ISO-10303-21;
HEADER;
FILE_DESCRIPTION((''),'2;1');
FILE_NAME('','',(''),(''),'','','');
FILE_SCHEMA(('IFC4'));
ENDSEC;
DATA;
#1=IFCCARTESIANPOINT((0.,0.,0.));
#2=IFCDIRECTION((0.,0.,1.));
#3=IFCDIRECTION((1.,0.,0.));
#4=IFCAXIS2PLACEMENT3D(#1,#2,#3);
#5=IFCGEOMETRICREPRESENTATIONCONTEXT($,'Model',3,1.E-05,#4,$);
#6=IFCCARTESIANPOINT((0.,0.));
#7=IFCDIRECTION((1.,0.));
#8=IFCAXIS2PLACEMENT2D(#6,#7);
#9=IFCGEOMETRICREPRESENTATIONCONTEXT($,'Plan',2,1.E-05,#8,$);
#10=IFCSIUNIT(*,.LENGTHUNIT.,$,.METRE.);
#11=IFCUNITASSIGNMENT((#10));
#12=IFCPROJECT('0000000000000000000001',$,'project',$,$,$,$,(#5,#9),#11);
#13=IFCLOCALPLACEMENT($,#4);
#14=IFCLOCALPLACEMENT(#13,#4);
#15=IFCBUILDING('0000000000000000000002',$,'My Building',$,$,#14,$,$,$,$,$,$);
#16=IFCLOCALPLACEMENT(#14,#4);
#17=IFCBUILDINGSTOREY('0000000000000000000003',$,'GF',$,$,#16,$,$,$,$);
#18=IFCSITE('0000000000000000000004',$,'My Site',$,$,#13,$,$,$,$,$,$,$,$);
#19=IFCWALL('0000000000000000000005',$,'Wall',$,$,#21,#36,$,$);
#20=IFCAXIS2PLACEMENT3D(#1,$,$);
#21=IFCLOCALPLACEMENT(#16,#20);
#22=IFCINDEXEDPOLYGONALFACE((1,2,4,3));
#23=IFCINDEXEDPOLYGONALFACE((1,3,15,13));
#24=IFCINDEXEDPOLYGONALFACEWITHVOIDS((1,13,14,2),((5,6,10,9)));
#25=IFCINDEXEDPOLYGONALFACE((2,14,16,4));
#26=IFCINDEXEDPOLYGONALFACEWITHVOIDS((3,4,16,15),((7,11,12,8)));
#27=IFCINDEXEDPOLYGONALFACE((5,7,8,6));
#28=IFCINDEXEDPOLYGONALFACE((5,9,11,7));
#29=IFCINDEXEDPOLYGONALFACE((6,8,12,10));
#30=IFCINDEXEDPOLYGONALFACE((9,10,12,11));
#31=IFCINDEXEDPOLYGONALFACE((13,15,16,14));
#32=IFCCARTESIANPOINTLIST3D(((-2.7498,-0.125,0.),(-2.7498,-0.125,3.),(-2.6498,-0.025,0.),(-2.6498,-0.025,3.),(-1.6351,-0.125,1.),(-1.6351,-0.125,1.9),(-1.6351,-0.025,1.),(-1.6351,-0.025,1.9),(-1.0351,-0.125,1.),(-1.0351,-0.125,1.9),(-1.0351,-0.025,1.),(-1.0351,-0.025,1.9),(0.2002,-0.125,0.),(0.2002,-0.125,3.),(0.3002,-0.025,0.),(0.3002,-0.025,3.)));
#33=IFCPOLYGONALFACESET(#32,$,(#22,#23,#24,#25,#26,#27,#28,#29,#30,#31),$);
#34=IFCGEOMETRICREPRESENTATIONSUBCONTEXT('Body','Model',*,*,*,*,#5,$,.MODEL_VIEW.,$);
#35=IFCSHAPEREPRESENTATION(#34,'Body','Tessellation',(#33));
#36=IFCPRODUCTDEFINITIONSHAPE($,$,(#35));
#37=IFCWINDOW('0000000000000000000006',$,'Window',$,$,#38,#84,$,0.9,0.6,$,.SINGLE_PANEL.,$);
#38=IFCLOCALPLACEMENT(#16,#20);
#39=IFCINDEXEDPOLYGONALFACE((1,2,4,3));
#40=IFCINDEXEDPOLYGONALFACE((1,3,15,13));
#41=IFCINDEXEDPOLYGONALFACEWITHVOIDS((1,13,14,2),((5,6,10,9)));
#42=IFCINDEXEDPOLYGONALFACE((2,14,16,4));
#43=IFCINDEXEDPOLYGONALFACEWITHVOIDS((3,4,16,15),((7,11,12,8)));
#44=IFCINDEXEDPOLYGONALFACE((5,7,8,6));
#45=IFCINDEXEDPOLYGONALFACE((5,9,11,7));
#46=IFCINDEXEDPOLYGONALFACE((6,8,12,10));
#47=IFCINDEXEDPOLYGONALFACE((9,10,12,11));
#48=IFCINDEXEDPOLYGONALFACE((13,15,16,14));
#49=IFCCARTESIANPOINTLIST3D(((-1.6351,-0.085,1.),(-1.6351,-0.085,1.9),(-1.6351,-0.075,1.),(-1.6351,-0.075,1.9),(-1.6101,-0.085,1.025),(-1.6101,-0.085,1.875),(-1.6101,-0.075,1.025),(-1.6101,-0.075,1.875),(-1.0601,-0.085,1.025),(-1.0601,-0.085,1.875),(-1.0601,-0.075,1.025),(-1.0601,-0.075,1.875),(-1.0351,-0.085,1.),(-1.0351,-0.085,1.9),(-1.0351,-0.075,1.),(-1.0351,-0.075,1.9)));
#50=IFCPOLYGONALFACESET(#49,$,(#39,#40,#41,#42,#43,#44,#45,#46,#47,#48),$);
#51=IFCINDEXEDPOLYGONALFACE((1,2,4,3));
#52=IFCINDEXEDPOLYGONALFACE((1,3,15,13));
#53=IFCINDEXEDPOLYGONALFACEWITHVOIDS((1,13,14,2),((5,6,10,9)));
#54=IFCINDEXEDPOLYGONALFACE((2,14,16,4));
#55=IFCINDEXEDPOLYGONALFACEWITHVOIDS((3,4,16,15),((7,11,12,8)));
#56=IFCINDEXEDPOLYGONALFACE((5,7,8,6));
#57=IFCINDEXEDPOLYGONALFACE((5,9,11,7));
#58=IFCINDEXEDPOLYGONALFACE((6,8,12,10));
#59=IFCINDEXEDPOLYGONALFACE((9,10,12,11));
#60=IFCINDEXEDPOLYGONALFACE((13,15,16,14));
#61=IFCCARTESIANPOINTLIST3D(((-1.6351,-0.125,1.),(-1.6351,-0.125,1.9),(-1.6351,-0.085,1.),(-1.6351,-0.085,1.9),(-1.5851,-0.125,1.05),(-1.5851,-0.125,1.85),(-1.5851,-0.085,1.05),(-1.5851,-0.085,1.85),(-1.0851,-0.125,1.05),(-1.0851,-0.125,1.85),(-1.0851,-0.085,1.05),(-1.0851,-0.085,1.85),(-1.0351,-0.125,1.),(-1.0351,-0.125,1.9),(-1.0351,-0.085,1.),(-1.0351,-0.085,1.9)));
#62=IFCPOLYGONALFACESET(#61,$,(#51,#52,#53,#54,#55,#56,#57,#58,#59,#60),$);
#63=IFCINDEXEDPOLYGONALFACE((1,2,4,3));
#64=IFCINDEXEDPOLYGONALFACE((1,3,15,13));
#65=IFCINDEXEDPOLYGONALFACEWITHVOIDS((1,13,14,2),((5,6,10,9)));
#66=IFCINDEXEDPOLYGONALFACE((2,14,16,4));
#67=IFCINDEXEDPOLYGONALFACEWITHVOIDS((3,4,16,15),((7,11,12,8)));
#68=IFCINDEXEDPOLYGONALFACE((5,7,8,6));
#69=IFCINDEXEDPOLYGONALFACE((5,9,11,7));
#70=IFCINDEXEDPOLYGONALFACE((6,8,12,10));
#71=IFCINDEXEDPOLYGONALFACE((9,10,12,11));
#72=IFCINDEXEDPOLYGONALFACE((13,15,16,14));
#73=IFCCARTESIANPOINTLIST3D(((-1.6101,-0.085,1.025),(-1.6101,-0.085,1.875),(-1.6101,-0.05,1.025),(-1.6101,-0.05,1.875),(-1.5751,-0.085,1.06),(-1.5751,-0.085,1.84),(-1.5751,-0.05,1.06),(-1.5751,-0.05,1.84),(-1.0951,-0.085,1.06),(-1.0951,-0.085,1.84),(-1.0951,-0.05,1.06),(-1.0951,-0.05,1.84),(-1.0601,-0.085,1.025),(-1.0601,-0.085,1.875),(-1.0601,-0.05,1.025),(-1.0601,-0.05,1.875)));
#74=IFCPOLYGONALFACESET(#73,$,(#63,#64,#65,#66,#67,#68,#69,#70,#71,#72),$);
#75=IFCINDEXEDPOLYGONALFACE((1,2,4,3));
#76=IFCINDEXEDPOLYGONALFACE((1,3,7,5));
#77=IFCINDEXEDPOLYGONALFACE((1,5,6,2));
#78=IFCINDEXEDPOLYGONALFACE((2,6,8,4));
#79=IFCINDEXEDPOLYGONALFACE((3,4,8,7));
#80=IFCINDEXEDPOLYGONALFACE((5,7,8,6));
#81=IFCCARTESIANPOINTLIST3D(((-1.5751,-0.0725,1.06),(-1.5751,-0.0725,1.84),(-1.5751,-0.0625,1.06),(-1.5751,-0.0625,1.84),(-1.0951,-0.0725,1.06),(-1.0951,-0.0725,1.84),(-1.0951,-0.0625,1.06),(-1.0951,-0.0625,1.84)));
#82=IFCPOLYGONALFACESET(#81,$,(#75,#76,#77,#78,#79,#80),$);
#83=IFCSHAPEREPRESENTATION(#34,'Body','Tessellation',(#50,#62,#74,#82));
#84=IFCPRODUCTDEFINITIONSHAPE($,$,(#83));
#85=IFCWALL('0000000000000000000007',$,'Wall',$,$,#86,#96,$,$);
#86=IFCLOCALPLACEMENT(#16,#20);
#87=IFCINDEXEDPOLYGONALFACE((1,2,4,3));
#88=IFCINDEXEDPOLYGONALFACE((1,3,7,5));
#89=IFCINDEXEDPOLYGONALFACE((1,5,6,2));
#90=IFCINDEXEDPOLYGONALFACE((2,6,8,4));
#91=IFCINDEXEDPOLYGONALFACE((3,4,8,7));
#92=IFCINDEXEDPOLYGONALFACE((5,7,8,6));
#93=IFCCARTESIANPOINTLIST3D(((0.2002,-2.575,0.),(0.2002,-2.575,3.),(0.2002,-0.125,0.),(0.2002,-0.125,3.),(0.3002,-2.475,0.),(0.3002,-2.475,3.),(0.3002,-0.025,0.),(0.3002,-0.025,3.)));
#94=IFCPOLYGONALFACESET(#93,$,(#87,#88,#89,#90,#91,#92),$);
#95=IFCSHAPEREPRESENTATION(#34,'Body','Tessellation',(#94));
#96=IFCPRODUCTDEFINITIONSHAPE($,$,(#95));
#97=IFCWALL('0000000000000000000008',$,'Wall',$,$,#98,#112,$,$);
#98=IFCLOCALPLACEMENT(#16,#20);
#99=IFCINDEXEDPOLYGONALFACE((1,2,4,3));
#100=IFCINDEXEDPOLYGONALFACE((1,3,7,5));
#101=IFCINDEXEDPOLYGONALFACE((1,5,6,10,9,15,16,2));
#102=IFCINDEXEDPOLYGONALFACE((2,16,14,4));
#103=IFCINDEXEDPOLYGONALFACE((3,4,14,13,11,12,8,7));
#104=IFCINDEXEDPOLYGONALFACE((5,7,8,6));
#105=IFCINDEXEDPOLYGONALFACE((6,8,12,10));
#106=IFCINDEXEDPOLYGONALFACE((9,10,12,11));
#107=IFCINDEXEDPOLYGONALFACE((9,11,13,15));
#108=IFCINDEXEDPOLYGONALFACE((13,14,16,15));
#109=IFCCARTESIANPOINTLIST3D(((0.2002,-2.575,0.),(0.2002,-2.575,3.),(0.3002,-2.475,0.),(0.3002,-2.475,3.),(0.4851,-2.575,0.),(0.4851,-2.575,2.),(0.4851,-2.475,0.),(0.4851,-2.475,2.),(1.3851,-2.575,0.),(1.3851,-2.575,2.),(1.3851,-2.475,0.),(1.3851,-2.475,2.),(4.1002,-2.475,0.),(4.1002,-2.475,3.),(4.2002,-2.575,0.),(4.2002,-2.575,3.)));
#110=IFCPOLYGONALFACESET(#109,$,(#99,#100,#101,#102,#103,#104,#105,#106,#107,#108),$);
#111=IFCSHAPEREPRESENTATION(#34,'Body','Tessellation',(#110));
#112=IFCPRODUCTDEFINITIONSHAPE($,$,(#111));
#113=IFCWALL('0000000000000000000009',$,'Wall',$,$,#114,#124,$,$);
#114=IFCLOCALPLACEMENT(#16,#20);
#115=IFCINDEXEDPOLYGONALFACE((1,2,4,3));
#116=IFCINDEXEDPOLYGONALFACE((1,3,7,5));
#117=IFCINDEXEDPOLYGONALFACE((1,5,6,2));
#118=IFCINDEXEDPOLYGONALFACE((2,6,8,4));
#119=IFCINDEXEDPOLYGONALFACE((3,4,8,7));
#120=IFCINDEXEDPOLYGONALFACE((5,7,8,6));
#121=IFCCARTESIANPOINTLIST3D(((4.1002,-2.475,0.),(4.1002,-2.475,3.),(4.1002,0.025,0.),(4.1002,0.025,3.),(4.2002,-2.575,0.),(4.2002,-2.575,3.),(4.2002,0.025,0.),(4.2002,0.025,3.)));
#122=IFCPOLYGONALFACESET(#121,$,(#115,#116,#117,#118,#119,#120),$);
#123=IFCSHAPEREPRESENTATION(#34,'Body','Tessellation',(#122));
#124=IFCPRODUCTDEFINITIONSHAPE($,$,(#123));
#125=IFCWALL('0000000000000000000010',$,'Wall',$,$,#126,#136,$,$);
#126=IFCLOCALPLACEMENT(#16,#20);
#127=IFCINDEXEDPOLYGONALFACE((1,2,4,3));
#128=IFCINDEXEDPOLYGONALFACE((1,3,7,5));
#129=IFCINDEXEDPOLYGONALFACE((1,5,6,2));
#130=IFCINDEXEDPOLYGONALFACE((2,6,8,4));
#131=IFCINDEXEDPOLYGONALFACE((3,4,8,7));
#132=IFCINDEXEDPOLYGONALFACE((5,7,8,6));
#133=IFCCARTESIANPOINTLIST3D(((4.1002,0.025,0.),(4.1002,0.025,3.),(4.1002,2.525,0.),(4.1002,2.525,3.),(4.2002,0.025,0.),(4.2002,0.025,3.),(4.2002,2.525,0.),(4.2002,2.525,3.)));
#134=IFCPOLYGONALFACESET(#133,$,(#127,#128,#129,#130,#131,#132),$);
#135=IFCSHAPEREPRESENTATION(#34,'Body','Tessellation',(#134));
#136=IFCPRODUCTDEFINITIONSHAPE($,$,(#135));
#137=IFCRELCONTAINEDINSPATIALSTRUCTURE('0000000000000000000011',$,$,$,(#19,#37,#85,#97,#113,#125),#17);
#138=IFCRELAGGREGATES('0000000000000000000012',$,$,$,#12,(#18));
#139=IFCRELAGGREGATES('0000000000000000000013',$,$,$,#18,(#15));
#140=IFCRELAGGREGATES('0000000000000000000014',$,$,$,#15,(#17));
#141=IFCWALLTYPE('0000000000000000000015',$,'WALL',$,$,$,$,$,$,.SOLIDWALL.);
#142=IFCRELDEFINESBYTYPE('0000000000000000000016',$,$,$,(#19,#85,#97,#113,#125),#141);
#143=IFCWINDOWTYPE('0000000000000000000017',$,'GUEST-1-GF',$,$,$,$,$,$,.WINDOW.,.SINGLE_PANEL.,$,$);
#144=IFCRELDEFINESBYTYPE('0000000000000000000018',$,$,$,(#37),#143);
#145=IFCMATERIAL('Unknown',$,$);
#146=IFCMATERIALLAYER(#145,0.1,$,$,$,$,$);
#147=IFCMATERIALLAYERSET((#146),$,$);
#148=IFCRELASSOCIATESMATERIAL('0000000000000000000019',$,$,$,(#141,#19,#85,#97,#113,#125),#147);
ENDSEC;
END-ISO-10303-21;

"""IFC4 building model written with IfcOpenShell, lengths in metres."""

from ifc_helpers import new_model, entity, si_unit, frame, origin_with_axes, origin_2d_with_axis, place, context, subcontext, project, spatial, line, indexed_curve, outline, extrude, shape, source, transform, mapped, material, layer, layer_set, layer_usage, type_object, type_shapes, element, fill, save


model = new_model("IFC4")

# Units and contexts
model_context = context("Model", 3, precision=1e-05, world=origin_with_axes())
plan_context = context("Plan", 2, precision=1e-05, world=origin_2d_with_axis())
body_context_1 = subcontext(model_context, "Body", "Model", "MODEL_VIEW")
body_context_2 = subcontext(plan_context, "Body", "Plan", "PLAN_VIEW")
ifc_project = project(units=[si_unit("LENGTHUNIT", "METRE")], contexts=[model_context, plan_context])

# Site, building, storey
site_placement = place(None, origin_with_axes())
site = spatial("IfcSite", under=ifc_project, at=site_placement, Name="My Site")
building_placement = place(site_placement, origin_with_axes())
building = spatial("IfcBuilding", under=site, at=building_placement, Name="My Building")
storey_placement = place(building_placement, origin_with_axes())
storey = spatial("IfcBuildingStorey", under=building, at=storey_placement, Name="GF")

# Shared definitions
ifc_material = material(Name="Unknown")

# Wall, opening, window
ifc_layer_1 = layer(ifc_material, 0.1)
ifc_layer_set_1 = layer_set([ifc_layer_1])
ifc_layer_usage_1 = layer_usage(ifc_layer_set_1, "AXIS2", "POSITIVE", 0.0)
wall_type = type_object("IfcWallType", Name="WALL", PredefinedType="SOLIDWALL", material=ifc_layer_set_1)
wall_1_placement = place(storey_placement, frame((-2.7498, -0.125, 0.0), z_axis=(0.0, 0.0, 1.0), x_axis=(1.0, 0.0, 0.0)))
wall_1 = element("IfcWall", 1, at=wall_1_placement, inside=storey, type_object=wall_type, material=ifc_layer_usage_1, Name="Wall", context=body_context_1, shape_type="SweptSolid", body=[
    extrude(outline(indexed_curve([(0.0, 0.0), (0.1, 0.1), (3.05, 0.1), (2.95, 0.0)], segments=[line(1, 2, 3, 4, 1)])), origin_with_axes(), (0.0, 0.0, 1.0), 3.0),
])
shared_shape_1 = source(origin_with_axes(), body_context_1, "Body", "SweptSolid", [
    extrude(outline(indexed_curve([(0.0, 0.0), (0.6, 0.0), (0.6, 0.9), (0.0, 0.9)], segments=[line(1, 2, 3, 4, 1)])), frame((0.0, -0.6, 0.0), z_axis=(0.0, -1.0, 0.0), x_axis=(1.0, 0.0, 0.0)), (0.0, 0.0, -1.0), 1.2),
])
opening_1_placement = place(wall_1_placement, frame((1.1146, -0.05, 1.0), z_axis=(0.0, 0.0, 1.0), x_axis=(1.0, 0.0, 0.0)))
opening_1 = element("IfcOpeningElement", 2, at=opening_1_placement, cuts=wall_1, PredefinedType="OPENING", context=body_context_1, shape_type="MappedRepresentation", body=[
    mapped(shared_shape_1, transform((0.0, 0.0, 0.0), x_axis=(1.0, 0.0, 0.0), y_axis=(0.0, 1.0, 0.0), z_axis=(0.0, 0.0, 1.0), scale=1.0)),
])
window_type_1 = type_object("IfcWindowType", Name="GUEST-1-GF", PartitioningType="SINGLE_PANEL", PredefinedType="WINDOW")
shared_shape_2 = source(origin_with_axes(), body_context_1, "Body", "SweptSolid", [
    extrude(outline(indexed_curve([(0.0, 0.0), (0.6, 0.0), (0.6, 0.9), (0.0, 0.9)], segments=[line(1, 2, 3, 4, 1)]), holes=[indexed_curve([(0.025, 0.025), (0.575, 0.025), (0.575, 0.875), (0.025, 0.875)], segments=[line(1, 2, 3, 4, 1)])]), frame((0.0, 0.09, 0.0), z_axis=(0.0, -1.0, 0.0), x_axis=(1.0, 0.0, 0.0)), (0.0, 0.0, -1.0), 0.01),
    extrude(outline(indexed_curve([(0.0, 0.0), (0.6, 0.0), (0.6, 0.9), (0.0, 0.9)], segments=[line(1, 2, 3, 4, 1)]), holes=[indexed_curve([(0.05, 0.05), (0.55, 0.05), (0.55, 0.85), (0.05, 0.85)], segments=[line(1, 2, 3, 4, 1)])]), frame((0.0, 0.05, 0.0), z_axis=(0.0, -1.0, 0.0), x_axis=(1.0, 0.0, 0.0)), (0.0, 0.0, -1.0), 0.04),
    extrude(outline(indexed_curve([(0.0, 0.0), (0.55, 0.0), (0.55, 0.85), (0.0, 0.85)], segments=[line(1, 2, 3, 4, 1)]), holes=[indexed_curve([(0.035, 0.035), (0.515, 0.035), (0.515, 0.815), (0.035, 0.815)], segments=[line(1, 2, 3, 4, 1)])]), frame((0.025, 0.09, 0.025), z_axis=(0.0, -1.0, 0.0), x_axis=(1.0, 0.0, 0.0)), (0.0, 0.0, -1.0), 0.035),
    extrude(outline(indexed_curve([(0.035, 0.035), (0.515, 0.035), (0.515, 0.815), (0.035, 0.815)], segments=[line(1, 2, 3, 4, 1)])), frame((0.025, 0.1025, 0.025), z_axis=(0.0, -1.0, 0.0), x_axis=(1.0, 0.0, 0.0)), (0.0, 0.0, -1.0), 0.01),
])
shared_shape_3 = source(origin_with_axes(), body_context_2, "Body", "Curve2D", [
    entity("IfcIndexedPolyCurve", entity("IfcCartesianPointList2D", [[0.05, 0.05], [0.55, 0.05]])),
    entity("IfcIndexedPolyCurve", entity("IfcCartesianPointList2D", [[0.0, 0.1], [0.025, 0.1], [0.025, 0.09], [0.05, 0.09], [0.05, 0.05], [0.0, 0.05]]), [entity("IfcLineIndex", [1, 2, 3, 4, 5, 6, 1])]),
    entity("IfcIndexedPolyCurve", entity("IfcCartesianPointList2D", [[0.6, 0.1], [0.575, 0.1], [0.575, 0.09], [0.55, 0.09], [0.55, 0.05], [0.6, 0.05]]), [entity("IfcLineIndex", [1, 2, 3, 4, 5, 6, 1])]),
    entity("IfcIndexedPolyCurve", entity("IfcCartesianPointList2D", [[0.025, 0.09], [0.06, 0.09], [0.06, 0.125], [0.025, 0.125]]), [entity("IfcLineIndex", [1, 2, 3, 4, 1])]),
    entity("IfcIndexedPolyCurve", entity("IfcCartesianPointList2D", [[0.575, 0.09], [0.54, 0.09], [0.54, 0.125], [0.575, 0.125]]), [entity("IfcLineIndex", [1, 2, 3, 4, 1])]),
    entity("IfcIndexedPolyCurve", entity("IfcCartesianPointList2D", [[0.06, 0.09], [0.54, 0.09]])),
    entity("IfcIndexedPolyCurve", entity("IfcCartesianPointList2D", [[0.06, 0.125], [0.54, 0.125]])),
    entity("IfcIndexedPolyCurve", entity("IfcCartesianPointList2D", [[0.06, 0.1075], [0.54, 0.1075]])),
])
type_shapes(window_type_1, [shared_shape_2, shared_shape_3])
window_1_placement = place(opening_1_placement, frame((0.0, 0.0, 0.0), z_axis=(0.0, 0.0, 1.0), x_axis=(1.0, 0.0, 0.0)))
window_1 = element("IfcWindow", 3, at=window_1_placement, inside=storey, type_object=window_type_1, Name="Window", OverallHeight=0.9, OverallWidth=0.6, PartitioningType="SINGLE_PANEL", shapes=[
    shape(body_context_1, "Body", "MappedRepresentation", [mapped(shared_shape_2, transform((0.0, 0.0, 0.0), x_axis=(1.0, 0.0, 0.0), y_axis=(0.0, 1.0, 0.0), z_axis=(0.0, 0.0, 1.0), scale=1.0))]),
    shape(body_context_2, "Body", "MappedRepresentation", [mapped(shared_shape_3, transform((0.0, 0.0, 0.0), x_axis=(1.0, 0.0, 0.0), y_axis=(0.0, 1.0, 0.0), z_axis=(0.0, 0.0, 1.0), scale=1.0))]),
])
fill(opening_1, window_1)

# Wall
ifc_layer_usage_2 = layer_usage(ifc_layer_set_1, "AXIS2", "POSITIVE", 0.0)
wall_2_placement = place(storey_placement, frame((0.2002, -0.125, 0.0), z_axis=(0.0, 0.0, 1.0), x_axis=(0.0, -1.0, 0.0)))
element("IfcWall", 4, at=wall_2_placement, inside=storey, type_object=wall_type, material=ifc_layer_usage_2, Name="Wall", context=body_context_1, shape_type="SweptSolid", body=[
    extrude(outline(indexed_curve([(0.0, 0.0), (-0.1, 0.1), (2.35, 0.1), (2.45, 0.0)], segments=[line(1, 2, 3, 4, 1)])), origin_with_axes(), (0.0, 0.0, 1.0), 3.0),
])

# Wall, opening
ifc_layer_usage_3 = layer_usage(ifc_layer_set_1, "AXIS2", "POSITIVE", 0.0)
wall_3_placement = place(storey_placement, frame((0.2002, -2.575, 0.0), z_axis=(0.0, 0.0, 1.0), x_axis=(1.0, 0.0, 0.0)))
wall_3 = element("IfcWall", 5, at=wall_3_placement, inside=storey, type_object=wall_type, material=ifc_layer_usage_3, Name="Wall", context=body_context_1, shape_type="SweptSolid", body=[
    extrude(outline(indexed_curve([(0.0, 0.0), (0.1, 0.1), (3.9, 0.1), (4.0, 0.0)], segments=[line(1, 2, 3, 4, 1)])), origin_with_axes(), (0.0, 0.0, 1.0), 3.0),
])
shared_shape_4 = source(origin_with_axes(), body_context_1, "Body", "SweptSolid", [
    extrude(outline(indexed_curve([(0.0, 0.0), (0.9, 0.0), (0.9, 2.0), (0.0, 2.0)], segments=[line(1, 2, 3, 4, 1)])), frame((0.0, -0.6, 0.0), z_axis=(0.0, -1.0, 0.0), x_axis=(1.0, 0.0, 0.0)), (0.0, 0.0, -1.0), 1.2),
])
opening_2_placement = place(wall_3_placement, frame((0.2849, 0.0, 0.0), z_axis=(0.0, 0.0, 1.0), x_axis=(1.0, 0.0, 0.0)))
element("IfcOpeningElement", 6, at=opening_2_placement, cuts=wall_3, PredefinedType="OPENING", context=body_context_1, shape_type="MappedRepresentation", body=[
    mapped(shared_shape_4, transform((0.0, 0.0, 0.0), x_axis=(1.0, 0.0, 0.0), y_axis=(0.0, 1.0, 0.0), z_axis=(0.0, 0.0, 1.0), scale=1.0)),
])

# Walls
ifc_layer_usage_4 = layer_usage(ifc_layer_set_1, "AXIS2", "POSITIVE", 0.0)
wall_4_placement = place(storey_placement, frame((4.2002, -2.575, 0.0), z_axis=(0.0, 0.0, 1.0), x_axis=(0.0, 1.0, 0.0)))
element("IfcWall", 7, at=wall_4_placement, inside=storey, type_object=wall_type, material=ifc_layer_usage_4, Name="Wall", context=body_context_1, shape_type="SweptSolid", body=[
    extrude(outline(indexed_curve([(0.0, 0.0), (0.1, 0.1), (2.6, 0.1), (2.6, 0.0)], segments=[line(1, 2, 3, 4, 1)])), origin_with_axes(), (0.0, 0.0, 1.0), 3.0),
])
ifc_layer_usage_5 = layer_usage(ifc_layer_set_1, "AXIS2", "POSITIVE", 0.0)
wall_5_placement = place(storey_placement, frame((4.2002, 0.025, 0.0), z_axis=(0.0, 0.0, 1.0), x_axis=(0.0, 1.0, 0.0)))
element("IfcWall", 8, at=wall_5_placement, inside=storey, type_object=wall_type, material=ifc_layer_usage_5, Name="Wall", context=body_context_1, shape_type="SweptSolid", body=[
    extrude(outline(indexed_curve([(0.0, 0.0), (0.0, 0.1), (2.5, 0.1), (2.5, 0.0)], segments=[line(1, 2, 3, 4, 1)])), origin_with_axes(), (0.0, 0.0, 1.0), 3.0),
])

save(model, "model.ifc")
